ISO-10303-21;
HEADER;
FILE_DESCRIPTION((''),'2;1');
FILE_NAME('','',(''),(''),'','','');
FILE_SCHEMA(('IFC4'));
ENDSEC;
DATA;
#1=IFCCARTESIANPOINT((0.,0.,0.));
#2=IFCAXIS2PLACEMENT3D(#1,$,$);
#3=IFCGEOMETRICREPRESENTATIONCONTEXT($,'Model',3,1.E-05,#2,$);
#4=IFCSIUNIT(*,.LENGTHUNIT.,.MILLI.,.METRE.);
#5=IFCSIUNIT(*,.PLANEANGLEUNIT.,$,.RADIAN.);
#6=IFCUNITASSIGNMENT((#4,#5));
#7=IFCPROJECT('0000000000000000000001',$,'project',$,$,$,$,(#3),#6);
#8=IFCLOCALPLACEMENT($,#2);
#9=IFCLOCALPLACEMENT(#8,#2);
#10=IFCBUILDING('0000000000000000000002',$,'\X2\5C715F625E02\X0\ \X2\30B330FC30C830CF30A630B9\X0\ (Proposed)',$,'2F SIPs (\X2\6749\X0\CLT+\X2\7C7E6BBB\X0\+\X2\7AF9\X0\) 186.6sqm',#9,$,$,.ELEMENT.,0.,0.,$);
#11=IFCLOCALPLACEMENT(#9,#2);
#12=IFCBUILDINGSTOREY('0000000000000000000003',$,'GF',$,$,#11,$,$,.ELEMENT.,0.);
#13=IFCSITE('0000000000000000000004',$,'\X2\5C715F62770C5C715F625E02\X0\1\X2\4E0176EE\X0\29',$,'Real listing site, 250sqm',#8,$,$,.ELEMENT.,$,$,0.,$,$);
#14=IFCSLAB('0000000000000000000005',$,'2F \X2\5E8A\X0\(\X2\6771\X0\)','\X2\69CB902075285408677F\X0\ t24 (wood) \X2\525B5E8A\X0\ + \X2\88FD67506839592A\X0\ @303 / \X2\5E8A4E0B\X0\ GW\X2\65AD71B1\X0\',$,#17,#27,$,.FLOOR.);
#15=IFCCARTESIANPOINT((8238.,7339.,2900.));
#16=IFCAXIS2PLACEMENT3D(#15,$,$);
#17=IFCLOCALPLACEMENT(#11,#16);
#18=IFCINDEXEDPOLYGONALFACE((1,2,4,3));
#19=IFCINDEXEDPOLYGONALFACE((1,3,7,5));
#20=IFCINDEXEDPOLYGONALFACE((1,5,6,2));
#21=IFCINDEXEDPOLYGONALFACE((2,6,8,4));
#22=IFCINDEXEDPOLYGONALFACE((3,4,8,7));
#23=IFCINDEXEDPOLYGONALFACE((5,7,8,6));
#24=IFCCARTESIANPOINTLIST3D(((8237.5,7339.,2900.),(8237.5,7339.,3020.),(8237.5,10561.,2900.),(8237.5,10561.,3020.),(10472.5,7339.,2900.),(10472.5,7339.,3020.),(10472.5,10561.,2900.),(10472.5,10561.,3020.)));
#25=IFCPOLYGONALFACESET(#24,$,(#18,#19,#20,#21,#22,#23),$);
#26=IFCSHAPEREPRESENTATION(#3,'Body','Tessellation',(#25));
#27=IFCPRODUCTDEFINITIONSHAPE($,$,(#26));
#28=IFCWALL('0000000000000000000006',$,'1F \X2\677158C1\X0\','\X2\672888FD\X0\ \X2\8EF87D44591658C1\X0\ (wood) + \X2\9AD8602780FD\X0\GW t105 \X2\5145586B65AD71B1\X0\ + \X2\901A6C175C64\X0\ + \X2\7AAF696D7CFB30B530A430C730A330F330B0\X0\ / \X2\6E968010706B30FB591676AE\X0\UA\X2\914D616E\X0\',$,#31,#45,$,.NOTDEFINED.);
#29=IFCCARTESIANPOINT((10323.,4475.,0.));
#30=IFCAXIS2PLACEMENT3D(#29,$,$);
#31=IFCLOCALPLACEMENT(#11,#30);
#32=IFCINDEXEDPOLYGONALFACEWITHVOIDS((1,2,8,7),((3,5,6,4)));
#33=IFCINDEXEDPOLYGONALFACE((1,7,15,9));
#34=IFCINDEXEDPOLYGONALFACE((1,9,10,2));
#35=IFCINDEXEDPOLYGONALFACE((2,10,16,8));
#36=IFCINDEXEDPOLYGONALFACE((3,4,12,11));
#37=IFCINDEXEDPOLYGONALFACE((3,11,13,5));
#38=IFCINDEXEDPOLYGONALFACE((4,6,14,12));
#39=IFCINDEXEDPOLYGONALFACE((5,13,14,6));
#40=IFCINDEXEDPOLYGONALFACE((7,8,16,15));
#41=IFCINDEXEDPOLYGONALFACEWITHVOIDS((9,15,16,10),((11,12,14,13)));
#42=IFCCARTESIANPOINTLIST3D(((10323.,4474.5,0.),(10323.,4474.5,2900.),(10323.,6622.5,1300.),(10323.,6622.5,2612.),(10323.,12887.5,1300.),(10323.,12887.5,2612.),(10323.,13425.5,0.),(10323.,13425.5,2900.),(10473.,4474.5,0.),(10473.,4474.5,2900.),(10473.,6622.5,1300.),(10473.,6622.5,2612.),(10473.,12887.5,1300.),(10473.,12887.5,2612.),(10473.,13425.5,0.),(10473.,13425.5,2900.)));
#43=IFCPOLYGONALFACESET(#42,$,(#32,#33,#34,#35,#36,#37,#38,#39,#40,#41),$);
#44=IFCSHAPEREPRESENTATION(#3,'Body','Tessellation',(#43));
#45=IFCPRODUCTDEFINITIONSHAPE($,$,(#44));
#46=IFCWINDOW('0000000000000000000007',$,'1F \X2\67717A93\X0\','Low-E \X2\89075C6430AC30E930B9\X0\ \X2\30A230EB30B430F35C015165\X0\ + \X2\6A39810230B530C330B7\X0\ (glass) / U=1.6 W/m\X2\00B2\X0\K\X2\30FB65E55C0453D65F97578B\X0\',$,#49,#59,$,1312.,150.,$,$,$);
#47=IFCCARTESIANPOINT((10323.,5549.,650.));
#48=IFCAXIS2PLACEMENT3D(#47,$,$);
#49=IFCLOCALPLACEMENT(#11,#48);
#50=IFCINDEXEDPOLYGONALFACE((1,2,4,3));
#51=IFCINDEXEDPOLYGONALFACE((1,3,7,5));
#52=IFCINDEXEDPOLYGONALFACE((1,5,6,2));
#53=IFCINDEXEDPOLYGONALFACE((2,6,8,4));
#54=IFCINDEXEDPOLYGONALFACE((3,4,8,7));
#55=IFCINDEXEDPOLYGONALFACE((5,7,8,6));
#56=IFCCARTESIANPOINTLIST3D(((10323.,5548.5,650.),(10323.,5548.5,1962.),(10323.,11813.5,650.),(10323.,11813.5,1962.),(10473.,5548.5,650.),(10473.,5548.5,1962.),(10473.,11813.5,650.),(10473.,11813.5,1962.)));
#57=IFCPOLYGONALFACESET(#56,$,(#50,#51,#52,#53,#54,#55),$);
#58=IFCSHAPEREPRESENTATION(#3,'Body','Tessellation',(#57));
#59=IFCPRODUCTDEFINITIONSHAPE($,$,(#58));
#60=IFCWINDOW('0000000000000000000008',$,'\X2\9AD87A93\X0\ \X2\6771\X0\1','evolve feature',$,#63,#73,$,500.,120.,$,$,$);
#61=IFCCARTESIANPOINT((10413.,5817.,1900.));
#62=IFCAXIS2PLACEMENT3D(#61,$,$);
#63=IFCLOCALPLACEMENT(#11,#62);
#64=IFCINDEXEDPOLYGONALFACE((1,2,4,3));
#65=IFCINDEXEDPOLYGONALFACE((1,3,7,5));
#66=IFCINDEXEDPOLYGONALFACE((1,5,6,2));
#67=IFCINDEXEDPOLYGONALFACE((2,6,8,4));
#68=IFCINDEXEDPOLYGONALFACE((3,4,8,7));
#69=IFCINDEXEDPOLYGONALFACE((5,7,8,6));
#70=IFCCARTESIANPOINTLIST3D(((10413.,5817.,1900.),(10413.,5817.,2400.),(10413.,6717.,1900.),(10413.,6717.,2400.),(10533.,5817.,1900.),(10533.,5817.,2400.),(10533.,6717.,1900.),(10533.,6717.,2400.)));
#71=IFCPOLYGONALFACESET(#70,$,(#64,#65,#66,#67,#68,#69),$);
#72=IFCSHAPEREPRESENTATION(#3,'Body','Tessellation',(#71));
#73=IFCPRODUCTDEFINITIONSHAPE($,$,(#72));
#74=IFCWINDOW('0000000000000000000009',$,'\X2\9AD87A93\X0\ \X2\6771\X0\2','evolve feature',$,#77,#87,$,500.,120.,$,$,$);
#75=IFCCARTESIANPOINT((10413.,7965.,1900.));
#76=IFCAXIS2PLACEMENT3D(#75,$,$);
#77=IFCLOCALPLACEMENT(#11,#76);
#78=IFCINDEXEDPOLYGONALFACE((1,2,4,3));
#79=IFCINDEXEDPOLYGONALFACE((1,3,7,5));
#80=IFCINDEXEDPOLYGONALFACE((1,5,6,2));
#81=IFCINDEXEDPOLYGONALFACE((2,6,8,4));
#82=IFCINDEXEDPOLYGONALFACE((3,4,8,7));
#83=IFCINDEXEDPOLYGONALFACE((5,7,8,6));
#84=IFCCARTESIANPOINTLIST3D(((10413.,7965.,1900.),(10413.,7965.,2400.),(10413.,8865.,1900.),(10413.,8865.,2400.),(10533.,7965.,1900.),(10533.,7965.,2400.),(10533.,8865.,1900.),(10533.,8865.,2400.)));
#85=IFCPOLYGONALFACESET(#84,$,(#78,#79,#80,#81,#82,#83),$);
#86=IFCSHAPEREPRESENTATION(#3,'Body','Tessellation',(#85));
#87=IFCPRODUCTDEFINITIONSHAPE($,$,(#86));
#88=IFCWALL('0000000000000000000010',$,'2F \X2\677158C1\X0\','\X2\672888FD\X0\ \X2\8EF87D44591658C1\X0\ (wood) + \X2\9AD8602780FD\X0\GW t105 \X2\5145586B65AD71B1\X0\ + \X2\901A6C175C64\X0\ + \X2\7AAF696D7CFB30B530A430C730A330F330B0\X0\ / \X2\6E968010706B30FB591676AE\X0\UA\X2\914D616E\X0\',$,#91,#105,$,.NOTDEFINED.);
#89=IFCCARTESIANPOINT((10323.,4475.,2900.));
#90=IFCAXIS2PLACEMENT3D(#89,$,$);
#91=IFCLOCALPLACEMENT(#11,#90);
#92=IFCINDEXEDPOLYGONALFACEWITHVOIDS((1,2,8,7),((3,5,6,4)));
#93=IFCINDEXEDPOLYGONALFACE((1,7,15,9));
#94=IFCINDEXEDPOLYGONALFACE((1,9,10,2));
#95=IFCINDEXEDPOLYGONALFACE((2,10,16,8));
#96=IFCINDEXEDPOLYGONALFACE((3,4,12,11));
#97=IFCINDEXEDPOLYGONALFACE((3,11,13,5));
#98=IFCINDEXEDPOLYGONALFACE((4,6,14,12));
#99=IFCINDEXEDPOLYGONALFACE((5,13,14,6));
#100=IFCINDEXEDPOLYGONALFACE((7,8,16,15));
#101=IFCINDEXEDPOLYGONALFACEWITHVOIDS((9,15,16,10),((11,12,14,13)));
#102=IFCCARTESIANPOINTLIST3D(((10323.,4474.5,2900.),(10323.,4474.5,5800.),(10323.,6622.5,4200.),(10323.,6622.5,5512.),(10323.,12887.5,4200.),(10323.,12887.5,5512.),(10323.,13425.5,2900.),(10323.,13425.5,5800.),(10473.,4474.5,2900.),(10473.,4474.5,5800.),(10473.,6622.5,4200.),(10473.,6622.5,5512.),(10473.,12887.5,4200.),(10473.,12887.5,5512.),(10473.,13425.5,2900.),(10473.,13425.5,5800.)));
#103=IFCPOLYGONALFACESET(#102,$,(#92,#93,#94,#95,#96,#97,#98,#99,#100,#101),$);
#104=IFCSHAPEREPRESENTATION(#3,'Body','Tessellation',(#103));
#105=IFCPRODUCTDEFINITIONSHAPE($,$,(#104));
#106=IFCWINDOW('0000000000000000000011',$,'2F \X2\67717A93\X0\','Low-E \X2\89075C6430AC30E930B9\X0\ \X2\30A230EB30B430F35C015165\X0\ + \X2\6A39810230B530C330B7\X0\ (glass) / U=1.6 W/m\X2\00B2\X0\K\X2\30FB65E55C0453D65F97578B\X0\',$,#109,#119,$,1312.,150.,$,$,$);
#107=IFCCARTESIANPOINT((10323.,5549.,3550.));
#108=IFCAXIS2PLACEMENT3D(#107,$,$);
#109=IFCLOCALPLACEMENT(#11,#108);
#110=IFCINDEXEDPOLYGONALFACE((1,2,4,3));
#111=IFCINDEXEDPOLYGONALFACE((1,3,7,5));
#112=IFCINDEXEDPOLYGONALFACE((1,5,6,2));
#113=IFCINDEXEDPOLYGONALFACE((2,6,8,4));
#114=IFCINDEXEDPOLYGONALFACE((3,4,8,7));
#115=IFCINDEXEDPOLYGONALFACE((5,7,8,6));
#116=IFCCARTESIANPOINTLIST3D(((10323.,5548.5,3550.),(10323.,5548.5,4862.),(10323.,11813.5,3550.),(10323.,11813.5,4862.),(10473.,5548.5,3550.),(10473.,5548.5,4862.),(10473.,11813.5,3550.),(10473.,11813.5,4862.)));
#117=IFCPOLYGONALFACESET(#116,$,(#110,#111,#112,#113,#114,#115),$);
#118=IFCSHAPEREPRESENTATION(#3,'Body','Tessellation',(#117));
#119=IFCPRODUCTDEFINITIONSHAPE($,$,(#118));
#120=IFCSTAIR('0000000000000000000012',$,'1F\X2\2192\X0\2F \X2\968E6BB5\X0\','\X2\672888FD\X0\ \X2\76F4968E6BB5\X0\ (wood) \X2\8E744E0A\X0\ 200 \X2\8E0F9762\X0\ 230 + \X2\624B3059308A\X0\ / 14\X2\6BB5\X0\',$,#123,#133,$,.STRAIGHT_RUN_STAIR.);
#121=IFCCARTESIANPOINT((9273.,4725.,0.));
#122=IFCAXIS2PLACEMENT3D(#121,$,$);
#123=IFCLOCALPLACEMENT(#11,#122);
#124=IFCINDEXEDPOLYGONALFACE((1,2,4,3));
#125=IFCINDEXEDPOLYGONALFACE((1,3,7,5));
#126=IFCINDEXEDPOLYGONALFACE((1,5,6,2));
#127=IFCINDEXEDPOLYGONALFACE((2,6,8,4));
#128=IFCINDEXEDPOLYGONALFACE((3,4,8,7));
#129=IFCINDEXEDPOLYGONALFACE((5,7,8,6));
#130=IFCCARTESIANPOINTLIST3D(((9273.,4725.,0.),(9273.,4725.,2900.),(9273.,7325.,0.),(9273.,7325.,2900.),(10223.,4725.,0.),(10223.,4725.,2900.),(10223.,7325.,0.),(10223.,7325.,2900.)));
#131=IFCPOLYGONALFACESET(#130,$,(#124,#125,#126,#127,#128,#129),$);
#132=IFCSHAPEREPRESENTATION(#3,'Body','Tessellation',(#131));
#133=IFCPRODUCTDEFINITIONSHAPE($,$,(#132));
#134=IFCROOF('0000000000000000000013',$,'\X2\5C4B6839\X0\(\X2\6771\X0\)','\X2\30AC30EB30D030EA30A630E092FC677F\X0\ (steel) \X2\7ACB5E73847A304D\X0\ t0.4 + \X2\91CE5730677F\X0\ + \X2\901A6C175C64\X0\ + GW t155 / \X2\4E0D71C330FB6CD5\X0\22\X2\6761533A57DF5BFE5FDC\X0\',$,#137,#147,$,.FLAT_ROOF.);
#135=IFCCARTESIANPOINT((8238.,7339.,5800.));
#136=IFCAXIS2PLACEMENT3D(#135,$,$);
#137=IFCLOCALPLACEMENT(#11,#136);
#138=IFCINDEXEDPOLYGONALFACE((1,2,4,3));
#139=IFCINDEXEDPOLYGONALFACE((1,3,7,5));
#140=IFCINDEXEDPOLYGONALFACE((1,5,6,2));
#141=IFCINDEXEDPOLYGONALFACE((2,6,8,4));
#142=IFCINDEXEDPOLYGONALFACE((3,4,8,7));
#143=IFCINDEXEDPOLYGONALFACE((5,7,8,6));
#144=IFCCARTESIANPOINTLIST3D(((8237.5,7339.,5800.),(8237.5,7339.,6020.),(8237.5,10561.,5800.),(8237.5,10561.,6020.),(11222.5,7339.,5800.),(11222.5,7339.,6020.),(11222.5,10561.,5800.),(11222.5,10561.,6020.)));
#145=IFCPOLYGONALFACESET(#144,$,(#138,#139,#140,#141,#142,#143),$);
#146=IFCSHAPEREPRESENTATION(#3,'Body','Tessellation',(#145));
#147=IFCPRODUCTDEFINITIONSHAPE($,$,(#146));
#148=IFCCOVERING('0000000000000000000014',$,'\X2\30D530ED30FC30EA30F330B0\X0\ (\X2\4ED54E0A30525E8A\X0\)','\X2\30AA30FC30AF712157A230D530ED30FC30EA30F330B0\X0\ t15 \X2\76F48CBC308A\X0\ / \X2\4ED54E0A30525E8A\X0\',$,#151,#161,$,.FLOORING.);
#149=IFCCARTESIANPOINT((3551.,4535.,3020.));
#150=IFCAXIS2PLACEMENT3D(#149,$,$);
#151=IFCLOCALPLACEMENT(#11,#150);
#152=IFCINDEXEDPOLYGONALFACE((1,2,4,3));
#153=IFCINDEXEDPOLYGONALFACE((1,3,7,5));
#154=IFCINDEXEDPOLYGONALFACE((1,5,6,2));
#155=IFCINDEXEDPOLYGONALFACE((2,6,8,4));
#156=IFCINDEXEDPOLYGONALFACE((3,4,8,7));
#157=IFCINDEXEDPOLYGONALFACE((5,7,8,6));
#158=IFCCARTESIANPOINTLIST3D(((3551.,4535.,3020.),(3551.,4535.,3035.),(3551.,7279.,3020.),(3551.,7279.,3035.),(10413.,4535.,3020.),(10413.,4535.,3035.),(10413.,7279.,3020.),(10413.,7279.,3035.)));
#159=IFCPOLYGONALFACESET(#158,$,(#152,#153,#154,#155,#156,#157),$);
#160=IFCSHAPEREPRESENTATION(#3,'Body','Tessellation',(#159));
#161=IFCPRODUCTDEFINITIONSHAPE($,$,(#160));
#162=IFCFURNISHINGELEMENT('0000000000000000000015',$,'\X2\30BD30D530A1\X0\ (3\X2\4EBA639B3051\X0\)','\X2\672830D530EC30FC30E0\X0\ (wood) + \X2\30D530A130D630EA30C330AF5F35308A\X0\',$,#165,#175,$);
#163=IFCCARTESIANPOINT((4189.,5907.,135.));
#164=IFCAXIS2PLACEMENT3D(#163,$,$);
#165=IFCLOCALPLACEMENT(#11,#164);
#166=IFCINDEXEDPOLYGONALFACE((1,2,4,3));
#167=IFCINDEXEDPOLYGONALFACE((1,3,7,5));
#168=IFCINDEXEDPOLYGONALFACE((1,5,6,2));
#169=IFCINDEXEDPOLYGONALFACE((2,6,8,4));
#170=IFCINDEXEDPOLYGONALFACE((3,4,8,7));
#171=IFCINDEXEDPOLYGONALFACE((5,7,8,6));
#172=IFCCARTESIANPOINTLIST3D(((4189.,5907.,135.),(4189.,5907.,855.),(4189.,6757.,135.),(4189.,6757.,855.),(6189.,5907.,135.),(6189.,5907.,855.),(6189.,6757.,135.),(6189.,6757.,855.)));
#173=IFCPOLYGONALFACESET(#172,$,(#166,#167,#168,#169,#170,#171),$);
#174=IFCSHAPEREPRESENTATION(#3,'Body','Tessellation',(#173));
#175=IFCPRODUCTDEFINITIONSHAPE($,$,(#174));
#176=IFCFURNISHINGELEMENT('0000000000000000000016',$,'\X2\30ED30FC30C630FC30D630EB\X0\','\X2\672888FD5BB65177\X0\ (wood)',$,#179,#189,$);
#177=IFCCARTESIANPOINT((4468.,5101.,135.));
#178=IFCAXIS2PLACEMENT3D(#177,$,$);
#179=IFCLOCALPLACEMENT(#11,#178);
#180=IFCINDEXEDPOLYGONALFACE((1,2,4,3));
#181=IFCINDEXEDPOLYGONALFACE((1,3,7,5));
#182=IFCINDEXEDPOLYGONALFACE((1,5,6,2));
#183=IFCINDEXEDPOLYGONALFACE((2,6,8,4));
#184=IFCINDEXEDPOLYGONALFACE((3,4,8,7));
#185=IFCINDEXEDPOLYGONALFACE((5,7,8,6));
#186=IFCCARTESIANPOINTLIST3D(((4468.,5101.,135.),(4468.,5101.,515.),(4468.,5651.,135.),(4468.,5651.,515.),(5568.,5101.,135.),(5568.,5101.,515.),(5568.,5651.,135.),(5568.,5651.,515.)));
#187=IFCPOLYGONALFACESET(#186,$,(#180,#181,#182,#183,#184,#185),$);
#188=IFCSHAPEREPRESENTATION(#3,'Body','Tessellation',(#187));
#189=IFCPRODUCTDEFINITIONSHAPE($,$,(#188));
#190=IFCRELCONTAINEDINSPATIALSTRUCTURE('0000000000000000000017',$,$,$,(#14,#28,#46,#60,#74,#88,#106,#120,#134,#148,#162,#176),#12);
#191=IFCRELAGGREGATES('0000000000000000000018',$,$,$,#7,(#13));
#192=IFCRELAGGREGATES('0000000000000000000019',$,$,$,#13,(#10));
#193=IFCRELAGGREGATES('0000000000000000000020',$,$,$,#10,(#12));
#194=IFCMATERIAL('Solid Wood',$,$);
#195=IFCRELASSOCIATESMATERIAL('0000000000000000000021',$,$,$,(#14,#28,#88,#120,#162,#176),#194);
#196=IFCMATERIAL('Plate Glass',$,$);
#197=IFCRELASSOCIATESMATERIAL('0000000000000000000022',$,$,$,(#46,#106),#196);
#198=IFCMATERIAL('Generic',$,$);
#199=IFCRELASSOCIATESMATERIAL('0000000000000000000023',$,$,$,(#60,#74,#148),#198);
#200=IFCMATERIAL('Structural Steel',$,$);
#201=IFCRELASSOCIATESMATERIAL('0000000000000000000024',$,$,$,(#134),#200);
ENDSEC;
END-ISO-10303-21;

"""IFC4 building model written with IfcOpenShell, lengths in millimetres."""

from ifc_helpers import new_model, si_unit, frame, frame_2d, origin, place, context, project, spatial, rectangle, extrude, material, element, fill, save


model = new_model("IFC4")

# Units and contexts
model_context = context("Model", 3, precision=1e-05, world=origin())
ifc_project = project(units=[si_unit("LENGTHUNIT", "METRE", prefix="MILLI"), si_unit("PLANEANGLEUNIT", "RADIAN")], contexts=[model_context])

# Site, building, storey
site_placement = place(None, origin())
site = spatial("IfcSite", under=ifc_project, at=site_placement, Name="山形県山形市1丁目29", ObjectType="Real listing site, 250sqm", CompositionType="ELEMENT", RefElevation=0.0)
building_placement = place(site_placement, origin())
building = spatial("IfcBuilding", under=site, at=building_placement, Name="山形市 コートハウス (Proposed)", ObjectType="2F SIPs (杉CLT+籾殻+竹) 186.6sqm", CompositionType="ELEMENT", ElevationOfRefHeight=0.0, ElevationOfTerrain=0.0)
storey_placement = place(building_placement, origin())
storey = spatial("IfcBuildingStorey", under=building, at=storey_placement, Name="GF", CompositionType="ELEMENT", Elevation=0.0)

# Slab
ifc_material_1 = material(Name="Solid Wood")
slab_1_placement = place(storey_placement, frame((8238.0, 7339.0, 2900.0)))
element("IfcSlab", 1, at=slab_1_placement, inside=storey, material=ifc_material_1, Name="2F 床(東)", Description="構造用合板 t24 (wood) 剛床 + 製材根太 @303 / 床下 GW断熱", PredefinedType="FLOOR", context=model_context, shape_type="SweptSolid", body=[
    extrude(rectangle(XDim=2235.0, YDim=3222.0, at=frame_2d((1117.0, 1611.0))), frame((8238.0, 7339.0, 2900.0)), (0.0, 0.0, 1.0), 120.0),
])

# Wall, openings, windows
wall_1_placement = place(storey_placement, frame((10323.0, 4475.0, 0.0)))
wall_1 = element("IfcWall", 2, at=wall_1_placement, inside=storey, material=ifc_material_1, Name="1F 東壁", Description="木製 軸組外壁 (wood) + 高性能GW t105 充填断熱 + 通気層 + 窯業系サイディング / 準耐火・外皮UA配慮", PredefinedType="NOTDEFINED", context=model_context, shape_type="SweptSolid", body=[
    extrude(rectangle(XDim=150.0, YDim=8951.0, at=frame_2d((75.0, 4475.0))), frame((10323.0, 4475.0, 0.0)), (0.0, 0.0, 1.0), 2900.0),
])
opening_1_placement = place(storey_placement, frame((10323.0, 5549.0, 650.0)))
opening_1 = element("IfcOpeningElement", 3, at=opening_1_placement, cuts=wall_1, PredefinedType="NOTDEFINED", context=model_context, shape_type="SweptSolid", body=[
    extrude(rectangle(XDim=150.0, YDim=6265.0, at=frame_2d((75.0, 3132.0))), frame((10323.0, 5549.0, 650.0)), (0.0, 0.0, 1.0), 1312.0),
])
opening_2_placement = place(storey_placement, frame((10413.0, 5817.0, 1900.0)))
opening_2 = element("IfcOpeningElement", 4, at=opening_2_placement, cuts=wall_1, PredefinedType="NOTDEFINED", context=model_context, shape_type="SweptSolid", body=[
    extrude(rectangle(XDim=120.0, YDim=900.0, at=frame_2d((60.0, 450.0))), frame((10413.0, 5817.0, 1900.0)), (0.0, 0.0, 1.0), 500.0),
])
opening_3_placement = place(storey_placement, frame((10413.0, 7965.0, 1900.0)))
opening_3 = element("IfcOpeningElement", 5, at=opening_3_placement, cuts=wall_1, PredefinedType="NOTDEFINED", context=model_context, shape_type="SweptSolid", body=[
    extrude(rectangle(XDim=120.0, YDim=900.0, at=frame_2d((60.0, 450.0))), frame((10413.0, 7965.0, 1900.0)), (0.0, 0.0, 1.0), 500.0),
])
ifc_material_2 = material(Name="Plate Glass")
window_1_placement = place(storey_placement, frame((10323.0, 5549.0, 650.0)))
window_1 = element("IfcWindow", 6, at=window_1_placement, inside=storey, material=ifc_material_2, Name="1F 東窓", Description="Low-E 複層ガラス アルゴン封入 + 樹脂サッシ (glass) / U=1.6 W/m²K・日射取得型", OverallHeight=1312.0, OverallWidth=150.0, context=model_context, shape_type="SweptSolid", body=[
    extrude(rectangle(XDim=150.0, YDim=6265.0, at=frame_2d((75.0, 3132.0))), frame((10323.0, 5549.0, 650.0)), (0.0, 0.0, 1.0), 1312.0),
])
fill(opening_1, window_1)
ifc_material_3 = material(Name="Generic")
window_2_placement = place(storey_placement, frame((10413.0, 5817.0, 1900.0)))
window_2 = element("IfcWindow", 7, at=window_2_placement, inside=storey, material=ifc_material_3, Name="高窓 東1", Description="evolve feature", OverallHeight=500.0, OverallWidth=120.0, context=model_context, shape_type="SweptSolid", body=[
    extrude(rectangle(XDim=120.0, YDim=900.0, at=frame_2d((60.0, 450.0))), frame((10413.0, 5817.0, 1900.0)), (0.0, 0.0, 1.0), 500.0),
])
fill(opening_2, window_2)
window_3_placement = place(storey_placement, frame((10413.0, 7965.0, 1900.0)))
window_3 = element("IfcWindow", 8, at=window_3_placement, inside=storey, material=ifc_material_3, Name="高窓 東2", Description="evolve feature", OverallHeight=500.0, OverallWidth=120.0, context=model_context, shape_type="SweptSolid", body=[
    extrude(rectangle(XDim=120.0, YDim=900.0, at=frame_2d((60.0, 450.0))), frame((10413.0, 7965.0, 1900.0)), (0.0, 0.0, 1.0), 500.0),
])
fill(opening_3, window_3)

# Wall, opening, window
wall_2_placement = place(storey_placement, frame((10323.0, 4475.0, 2900.0)))
wall_2 = element("IfcWall", 9, at=wall_2_placement, inside=storey, material=ifc_material_1, Name="2F 東壁", Description="木製 軸組外壁 (wood) + 高性能GW t105 充填断熱 + 通気層 + 窯業系サイディング / 準耐火・外皮UA配慮", PredefinedType="NOTDEFINED", context=model_context, shape_type="SweptSolid", body=[
    extrude(rectangle(XDim=150.0, YDim=8951.0, at=frame_2d((75.0, 4475.0))), frame((10323.0, 4475.0, 2900.0)), (0.0, 0.0, 1.0), 2900.0),
])
opening_4_placement = place(storey_placement, frame((10323.0, 5549.0, 3550.0)))
opening_4 = element("IfcOpeningElement", 10, at=opening_4_placement, cuts=wall_2, PredefinedType="NOTDEFINED", context=model_context, shape_type="SweptSolid", body=[
    extrude(rectangle(XDim=150.0, YDim=6265.0, at=frame_2d((75.0, 3132.0))), frame((10323.0, 5549.0, 3550.0)), (0.0, 0.0, 1.0), 1312.0),
])
window_4_placement = place(storey_placement, frame((10323.0, 5549.0, 3550.0)))
window_4 = element("IfcWindow", 11, at=window_4_placement, inside=storey, material=ifc_material_2, Name="2F 東窓", Description="Low-E 複層ガラス アルゴン封入 + 樹脂サッシ (glass) / U=1.6 W/m²K・日射取得型", OverallHeight=1312.0, OverallWidth=150.0, context=model_context, shape_type="SweptSolid", body=[
    extrude(rectangle(XDim=150.0, YDim=6265.0, at=frame_2d((75.0, 3132.0))), frame((10323.0, 5549.0, 3550.0)), (0.0, 0.0, 1.0), 1312.0),
])
fill(opening_4, window_4)

# Stair
stair_placement = place(storey_placement, frame((9273.0, 4725.0, 0.0)))
element("IfcStair", 12, at=stair_placement, inside=storey, material=ifc_material_1, Name="1F→2F 階段", Description="木製 直階段 (wood) 蹴上 200 踏面 230 + 手すり / 14段", PredefinedType="STRAIGHT_RUN_STAIR", context=model_context, shape_type="SweptSolid", body=[
    extrude(rectangle(XDim=950.0, YDim=2600.0, at=frame_2d((475.0, 1300.0))), frame((9273.0, 4725.0, 0.0)), (0.0, 0.0, 1.0), 2900.0),
])

# Roof
ifc_material_4 = material(Name="Structural Steel")
roof_placement = place(storey_placement, frame((8238.0, 7339.0, 5800.0)))
element("IfcRoof", 13, at=roof_placement, inside=storey, material=ifc_material_4, Name="屋根(東)", Description="ガルバリウム鋼板 (steel) 立平葺き t0.4 + 野地板 + 通気層 + GW t155 / 不燃・法22条区域対応", PredefinedType="FLAT_ROOF", context=model_context, shape_type="SweptSolid", body=[
    extrude(rectangle(XDim=2985.0, YDim=3222.0, at=frame_2d((1492.0, 1611.0))), frame((8238.0, 7339.0, 5800.0)), (0.0, 0.0, 1.0), 220.0),
])

# Covering
covering_placement = place(storey_placement, frame((3551.0, 4535.0, 3020.0)))
element("IfcCovering", 14, at=covering_placement, inside=storey, material=ifc_material_3, Name="フローリング (仕上げ床)", Description="オーク無垢フローリング t15 直貼り / 仕上げ床", PredefinedType="FLOORING", context=model_context, shape_type="SweptSolid", body=[
    extrude(rectangle(XDim=6862.0, YDim=2744.0, at=frame_2d((3431.0, 1372.0))), frame((3551.0, 4535.0, 3020.0)), (0.0, 0.0, 1.0), 15.0),
])

# Furnishing elements
furnishing_1_placement = place(storey_placement, frame((4189.0, 5907.0, 135.0)))
element("IfcFurnishingElement", 15, at=furnishing_1_placement, inside=storey, material=ifc_material_1, Name="ソファ (3人掛け)", Description="木フレーム (wood) + ファブリック張り", context=model_context, shape_type="SweptSolid", body=[
    extrude(rectangle(XDim=2000.0, YDim=850.0, at=frame_2d((1000.0, 425.0))), frame((4189.0, 5907.0, 135.0)), (0.0, 0.0, 1.0), 720.0),
])
furnishing_2_placement = place(storey_placement, frame((4468.0, 5101.0, 135.0)))
element("IfcFurnishingElement", 16, at=furnishing_2_placement, inside=storey, material=ifc_material_1, Name="ローテーブル", Description="木製家具 (wood)", context=model_context, shape_type="SweptSolid", body=[
    extrude(rectangle(XDim=1100.0, YDim=550.0, at=frame_2d((550.0, 275.0))), frame((4468.0, 5101.0, 135.0)), (0.0, 0.0, 1.0), 380.0),
])

save(model, "model.ifc")
